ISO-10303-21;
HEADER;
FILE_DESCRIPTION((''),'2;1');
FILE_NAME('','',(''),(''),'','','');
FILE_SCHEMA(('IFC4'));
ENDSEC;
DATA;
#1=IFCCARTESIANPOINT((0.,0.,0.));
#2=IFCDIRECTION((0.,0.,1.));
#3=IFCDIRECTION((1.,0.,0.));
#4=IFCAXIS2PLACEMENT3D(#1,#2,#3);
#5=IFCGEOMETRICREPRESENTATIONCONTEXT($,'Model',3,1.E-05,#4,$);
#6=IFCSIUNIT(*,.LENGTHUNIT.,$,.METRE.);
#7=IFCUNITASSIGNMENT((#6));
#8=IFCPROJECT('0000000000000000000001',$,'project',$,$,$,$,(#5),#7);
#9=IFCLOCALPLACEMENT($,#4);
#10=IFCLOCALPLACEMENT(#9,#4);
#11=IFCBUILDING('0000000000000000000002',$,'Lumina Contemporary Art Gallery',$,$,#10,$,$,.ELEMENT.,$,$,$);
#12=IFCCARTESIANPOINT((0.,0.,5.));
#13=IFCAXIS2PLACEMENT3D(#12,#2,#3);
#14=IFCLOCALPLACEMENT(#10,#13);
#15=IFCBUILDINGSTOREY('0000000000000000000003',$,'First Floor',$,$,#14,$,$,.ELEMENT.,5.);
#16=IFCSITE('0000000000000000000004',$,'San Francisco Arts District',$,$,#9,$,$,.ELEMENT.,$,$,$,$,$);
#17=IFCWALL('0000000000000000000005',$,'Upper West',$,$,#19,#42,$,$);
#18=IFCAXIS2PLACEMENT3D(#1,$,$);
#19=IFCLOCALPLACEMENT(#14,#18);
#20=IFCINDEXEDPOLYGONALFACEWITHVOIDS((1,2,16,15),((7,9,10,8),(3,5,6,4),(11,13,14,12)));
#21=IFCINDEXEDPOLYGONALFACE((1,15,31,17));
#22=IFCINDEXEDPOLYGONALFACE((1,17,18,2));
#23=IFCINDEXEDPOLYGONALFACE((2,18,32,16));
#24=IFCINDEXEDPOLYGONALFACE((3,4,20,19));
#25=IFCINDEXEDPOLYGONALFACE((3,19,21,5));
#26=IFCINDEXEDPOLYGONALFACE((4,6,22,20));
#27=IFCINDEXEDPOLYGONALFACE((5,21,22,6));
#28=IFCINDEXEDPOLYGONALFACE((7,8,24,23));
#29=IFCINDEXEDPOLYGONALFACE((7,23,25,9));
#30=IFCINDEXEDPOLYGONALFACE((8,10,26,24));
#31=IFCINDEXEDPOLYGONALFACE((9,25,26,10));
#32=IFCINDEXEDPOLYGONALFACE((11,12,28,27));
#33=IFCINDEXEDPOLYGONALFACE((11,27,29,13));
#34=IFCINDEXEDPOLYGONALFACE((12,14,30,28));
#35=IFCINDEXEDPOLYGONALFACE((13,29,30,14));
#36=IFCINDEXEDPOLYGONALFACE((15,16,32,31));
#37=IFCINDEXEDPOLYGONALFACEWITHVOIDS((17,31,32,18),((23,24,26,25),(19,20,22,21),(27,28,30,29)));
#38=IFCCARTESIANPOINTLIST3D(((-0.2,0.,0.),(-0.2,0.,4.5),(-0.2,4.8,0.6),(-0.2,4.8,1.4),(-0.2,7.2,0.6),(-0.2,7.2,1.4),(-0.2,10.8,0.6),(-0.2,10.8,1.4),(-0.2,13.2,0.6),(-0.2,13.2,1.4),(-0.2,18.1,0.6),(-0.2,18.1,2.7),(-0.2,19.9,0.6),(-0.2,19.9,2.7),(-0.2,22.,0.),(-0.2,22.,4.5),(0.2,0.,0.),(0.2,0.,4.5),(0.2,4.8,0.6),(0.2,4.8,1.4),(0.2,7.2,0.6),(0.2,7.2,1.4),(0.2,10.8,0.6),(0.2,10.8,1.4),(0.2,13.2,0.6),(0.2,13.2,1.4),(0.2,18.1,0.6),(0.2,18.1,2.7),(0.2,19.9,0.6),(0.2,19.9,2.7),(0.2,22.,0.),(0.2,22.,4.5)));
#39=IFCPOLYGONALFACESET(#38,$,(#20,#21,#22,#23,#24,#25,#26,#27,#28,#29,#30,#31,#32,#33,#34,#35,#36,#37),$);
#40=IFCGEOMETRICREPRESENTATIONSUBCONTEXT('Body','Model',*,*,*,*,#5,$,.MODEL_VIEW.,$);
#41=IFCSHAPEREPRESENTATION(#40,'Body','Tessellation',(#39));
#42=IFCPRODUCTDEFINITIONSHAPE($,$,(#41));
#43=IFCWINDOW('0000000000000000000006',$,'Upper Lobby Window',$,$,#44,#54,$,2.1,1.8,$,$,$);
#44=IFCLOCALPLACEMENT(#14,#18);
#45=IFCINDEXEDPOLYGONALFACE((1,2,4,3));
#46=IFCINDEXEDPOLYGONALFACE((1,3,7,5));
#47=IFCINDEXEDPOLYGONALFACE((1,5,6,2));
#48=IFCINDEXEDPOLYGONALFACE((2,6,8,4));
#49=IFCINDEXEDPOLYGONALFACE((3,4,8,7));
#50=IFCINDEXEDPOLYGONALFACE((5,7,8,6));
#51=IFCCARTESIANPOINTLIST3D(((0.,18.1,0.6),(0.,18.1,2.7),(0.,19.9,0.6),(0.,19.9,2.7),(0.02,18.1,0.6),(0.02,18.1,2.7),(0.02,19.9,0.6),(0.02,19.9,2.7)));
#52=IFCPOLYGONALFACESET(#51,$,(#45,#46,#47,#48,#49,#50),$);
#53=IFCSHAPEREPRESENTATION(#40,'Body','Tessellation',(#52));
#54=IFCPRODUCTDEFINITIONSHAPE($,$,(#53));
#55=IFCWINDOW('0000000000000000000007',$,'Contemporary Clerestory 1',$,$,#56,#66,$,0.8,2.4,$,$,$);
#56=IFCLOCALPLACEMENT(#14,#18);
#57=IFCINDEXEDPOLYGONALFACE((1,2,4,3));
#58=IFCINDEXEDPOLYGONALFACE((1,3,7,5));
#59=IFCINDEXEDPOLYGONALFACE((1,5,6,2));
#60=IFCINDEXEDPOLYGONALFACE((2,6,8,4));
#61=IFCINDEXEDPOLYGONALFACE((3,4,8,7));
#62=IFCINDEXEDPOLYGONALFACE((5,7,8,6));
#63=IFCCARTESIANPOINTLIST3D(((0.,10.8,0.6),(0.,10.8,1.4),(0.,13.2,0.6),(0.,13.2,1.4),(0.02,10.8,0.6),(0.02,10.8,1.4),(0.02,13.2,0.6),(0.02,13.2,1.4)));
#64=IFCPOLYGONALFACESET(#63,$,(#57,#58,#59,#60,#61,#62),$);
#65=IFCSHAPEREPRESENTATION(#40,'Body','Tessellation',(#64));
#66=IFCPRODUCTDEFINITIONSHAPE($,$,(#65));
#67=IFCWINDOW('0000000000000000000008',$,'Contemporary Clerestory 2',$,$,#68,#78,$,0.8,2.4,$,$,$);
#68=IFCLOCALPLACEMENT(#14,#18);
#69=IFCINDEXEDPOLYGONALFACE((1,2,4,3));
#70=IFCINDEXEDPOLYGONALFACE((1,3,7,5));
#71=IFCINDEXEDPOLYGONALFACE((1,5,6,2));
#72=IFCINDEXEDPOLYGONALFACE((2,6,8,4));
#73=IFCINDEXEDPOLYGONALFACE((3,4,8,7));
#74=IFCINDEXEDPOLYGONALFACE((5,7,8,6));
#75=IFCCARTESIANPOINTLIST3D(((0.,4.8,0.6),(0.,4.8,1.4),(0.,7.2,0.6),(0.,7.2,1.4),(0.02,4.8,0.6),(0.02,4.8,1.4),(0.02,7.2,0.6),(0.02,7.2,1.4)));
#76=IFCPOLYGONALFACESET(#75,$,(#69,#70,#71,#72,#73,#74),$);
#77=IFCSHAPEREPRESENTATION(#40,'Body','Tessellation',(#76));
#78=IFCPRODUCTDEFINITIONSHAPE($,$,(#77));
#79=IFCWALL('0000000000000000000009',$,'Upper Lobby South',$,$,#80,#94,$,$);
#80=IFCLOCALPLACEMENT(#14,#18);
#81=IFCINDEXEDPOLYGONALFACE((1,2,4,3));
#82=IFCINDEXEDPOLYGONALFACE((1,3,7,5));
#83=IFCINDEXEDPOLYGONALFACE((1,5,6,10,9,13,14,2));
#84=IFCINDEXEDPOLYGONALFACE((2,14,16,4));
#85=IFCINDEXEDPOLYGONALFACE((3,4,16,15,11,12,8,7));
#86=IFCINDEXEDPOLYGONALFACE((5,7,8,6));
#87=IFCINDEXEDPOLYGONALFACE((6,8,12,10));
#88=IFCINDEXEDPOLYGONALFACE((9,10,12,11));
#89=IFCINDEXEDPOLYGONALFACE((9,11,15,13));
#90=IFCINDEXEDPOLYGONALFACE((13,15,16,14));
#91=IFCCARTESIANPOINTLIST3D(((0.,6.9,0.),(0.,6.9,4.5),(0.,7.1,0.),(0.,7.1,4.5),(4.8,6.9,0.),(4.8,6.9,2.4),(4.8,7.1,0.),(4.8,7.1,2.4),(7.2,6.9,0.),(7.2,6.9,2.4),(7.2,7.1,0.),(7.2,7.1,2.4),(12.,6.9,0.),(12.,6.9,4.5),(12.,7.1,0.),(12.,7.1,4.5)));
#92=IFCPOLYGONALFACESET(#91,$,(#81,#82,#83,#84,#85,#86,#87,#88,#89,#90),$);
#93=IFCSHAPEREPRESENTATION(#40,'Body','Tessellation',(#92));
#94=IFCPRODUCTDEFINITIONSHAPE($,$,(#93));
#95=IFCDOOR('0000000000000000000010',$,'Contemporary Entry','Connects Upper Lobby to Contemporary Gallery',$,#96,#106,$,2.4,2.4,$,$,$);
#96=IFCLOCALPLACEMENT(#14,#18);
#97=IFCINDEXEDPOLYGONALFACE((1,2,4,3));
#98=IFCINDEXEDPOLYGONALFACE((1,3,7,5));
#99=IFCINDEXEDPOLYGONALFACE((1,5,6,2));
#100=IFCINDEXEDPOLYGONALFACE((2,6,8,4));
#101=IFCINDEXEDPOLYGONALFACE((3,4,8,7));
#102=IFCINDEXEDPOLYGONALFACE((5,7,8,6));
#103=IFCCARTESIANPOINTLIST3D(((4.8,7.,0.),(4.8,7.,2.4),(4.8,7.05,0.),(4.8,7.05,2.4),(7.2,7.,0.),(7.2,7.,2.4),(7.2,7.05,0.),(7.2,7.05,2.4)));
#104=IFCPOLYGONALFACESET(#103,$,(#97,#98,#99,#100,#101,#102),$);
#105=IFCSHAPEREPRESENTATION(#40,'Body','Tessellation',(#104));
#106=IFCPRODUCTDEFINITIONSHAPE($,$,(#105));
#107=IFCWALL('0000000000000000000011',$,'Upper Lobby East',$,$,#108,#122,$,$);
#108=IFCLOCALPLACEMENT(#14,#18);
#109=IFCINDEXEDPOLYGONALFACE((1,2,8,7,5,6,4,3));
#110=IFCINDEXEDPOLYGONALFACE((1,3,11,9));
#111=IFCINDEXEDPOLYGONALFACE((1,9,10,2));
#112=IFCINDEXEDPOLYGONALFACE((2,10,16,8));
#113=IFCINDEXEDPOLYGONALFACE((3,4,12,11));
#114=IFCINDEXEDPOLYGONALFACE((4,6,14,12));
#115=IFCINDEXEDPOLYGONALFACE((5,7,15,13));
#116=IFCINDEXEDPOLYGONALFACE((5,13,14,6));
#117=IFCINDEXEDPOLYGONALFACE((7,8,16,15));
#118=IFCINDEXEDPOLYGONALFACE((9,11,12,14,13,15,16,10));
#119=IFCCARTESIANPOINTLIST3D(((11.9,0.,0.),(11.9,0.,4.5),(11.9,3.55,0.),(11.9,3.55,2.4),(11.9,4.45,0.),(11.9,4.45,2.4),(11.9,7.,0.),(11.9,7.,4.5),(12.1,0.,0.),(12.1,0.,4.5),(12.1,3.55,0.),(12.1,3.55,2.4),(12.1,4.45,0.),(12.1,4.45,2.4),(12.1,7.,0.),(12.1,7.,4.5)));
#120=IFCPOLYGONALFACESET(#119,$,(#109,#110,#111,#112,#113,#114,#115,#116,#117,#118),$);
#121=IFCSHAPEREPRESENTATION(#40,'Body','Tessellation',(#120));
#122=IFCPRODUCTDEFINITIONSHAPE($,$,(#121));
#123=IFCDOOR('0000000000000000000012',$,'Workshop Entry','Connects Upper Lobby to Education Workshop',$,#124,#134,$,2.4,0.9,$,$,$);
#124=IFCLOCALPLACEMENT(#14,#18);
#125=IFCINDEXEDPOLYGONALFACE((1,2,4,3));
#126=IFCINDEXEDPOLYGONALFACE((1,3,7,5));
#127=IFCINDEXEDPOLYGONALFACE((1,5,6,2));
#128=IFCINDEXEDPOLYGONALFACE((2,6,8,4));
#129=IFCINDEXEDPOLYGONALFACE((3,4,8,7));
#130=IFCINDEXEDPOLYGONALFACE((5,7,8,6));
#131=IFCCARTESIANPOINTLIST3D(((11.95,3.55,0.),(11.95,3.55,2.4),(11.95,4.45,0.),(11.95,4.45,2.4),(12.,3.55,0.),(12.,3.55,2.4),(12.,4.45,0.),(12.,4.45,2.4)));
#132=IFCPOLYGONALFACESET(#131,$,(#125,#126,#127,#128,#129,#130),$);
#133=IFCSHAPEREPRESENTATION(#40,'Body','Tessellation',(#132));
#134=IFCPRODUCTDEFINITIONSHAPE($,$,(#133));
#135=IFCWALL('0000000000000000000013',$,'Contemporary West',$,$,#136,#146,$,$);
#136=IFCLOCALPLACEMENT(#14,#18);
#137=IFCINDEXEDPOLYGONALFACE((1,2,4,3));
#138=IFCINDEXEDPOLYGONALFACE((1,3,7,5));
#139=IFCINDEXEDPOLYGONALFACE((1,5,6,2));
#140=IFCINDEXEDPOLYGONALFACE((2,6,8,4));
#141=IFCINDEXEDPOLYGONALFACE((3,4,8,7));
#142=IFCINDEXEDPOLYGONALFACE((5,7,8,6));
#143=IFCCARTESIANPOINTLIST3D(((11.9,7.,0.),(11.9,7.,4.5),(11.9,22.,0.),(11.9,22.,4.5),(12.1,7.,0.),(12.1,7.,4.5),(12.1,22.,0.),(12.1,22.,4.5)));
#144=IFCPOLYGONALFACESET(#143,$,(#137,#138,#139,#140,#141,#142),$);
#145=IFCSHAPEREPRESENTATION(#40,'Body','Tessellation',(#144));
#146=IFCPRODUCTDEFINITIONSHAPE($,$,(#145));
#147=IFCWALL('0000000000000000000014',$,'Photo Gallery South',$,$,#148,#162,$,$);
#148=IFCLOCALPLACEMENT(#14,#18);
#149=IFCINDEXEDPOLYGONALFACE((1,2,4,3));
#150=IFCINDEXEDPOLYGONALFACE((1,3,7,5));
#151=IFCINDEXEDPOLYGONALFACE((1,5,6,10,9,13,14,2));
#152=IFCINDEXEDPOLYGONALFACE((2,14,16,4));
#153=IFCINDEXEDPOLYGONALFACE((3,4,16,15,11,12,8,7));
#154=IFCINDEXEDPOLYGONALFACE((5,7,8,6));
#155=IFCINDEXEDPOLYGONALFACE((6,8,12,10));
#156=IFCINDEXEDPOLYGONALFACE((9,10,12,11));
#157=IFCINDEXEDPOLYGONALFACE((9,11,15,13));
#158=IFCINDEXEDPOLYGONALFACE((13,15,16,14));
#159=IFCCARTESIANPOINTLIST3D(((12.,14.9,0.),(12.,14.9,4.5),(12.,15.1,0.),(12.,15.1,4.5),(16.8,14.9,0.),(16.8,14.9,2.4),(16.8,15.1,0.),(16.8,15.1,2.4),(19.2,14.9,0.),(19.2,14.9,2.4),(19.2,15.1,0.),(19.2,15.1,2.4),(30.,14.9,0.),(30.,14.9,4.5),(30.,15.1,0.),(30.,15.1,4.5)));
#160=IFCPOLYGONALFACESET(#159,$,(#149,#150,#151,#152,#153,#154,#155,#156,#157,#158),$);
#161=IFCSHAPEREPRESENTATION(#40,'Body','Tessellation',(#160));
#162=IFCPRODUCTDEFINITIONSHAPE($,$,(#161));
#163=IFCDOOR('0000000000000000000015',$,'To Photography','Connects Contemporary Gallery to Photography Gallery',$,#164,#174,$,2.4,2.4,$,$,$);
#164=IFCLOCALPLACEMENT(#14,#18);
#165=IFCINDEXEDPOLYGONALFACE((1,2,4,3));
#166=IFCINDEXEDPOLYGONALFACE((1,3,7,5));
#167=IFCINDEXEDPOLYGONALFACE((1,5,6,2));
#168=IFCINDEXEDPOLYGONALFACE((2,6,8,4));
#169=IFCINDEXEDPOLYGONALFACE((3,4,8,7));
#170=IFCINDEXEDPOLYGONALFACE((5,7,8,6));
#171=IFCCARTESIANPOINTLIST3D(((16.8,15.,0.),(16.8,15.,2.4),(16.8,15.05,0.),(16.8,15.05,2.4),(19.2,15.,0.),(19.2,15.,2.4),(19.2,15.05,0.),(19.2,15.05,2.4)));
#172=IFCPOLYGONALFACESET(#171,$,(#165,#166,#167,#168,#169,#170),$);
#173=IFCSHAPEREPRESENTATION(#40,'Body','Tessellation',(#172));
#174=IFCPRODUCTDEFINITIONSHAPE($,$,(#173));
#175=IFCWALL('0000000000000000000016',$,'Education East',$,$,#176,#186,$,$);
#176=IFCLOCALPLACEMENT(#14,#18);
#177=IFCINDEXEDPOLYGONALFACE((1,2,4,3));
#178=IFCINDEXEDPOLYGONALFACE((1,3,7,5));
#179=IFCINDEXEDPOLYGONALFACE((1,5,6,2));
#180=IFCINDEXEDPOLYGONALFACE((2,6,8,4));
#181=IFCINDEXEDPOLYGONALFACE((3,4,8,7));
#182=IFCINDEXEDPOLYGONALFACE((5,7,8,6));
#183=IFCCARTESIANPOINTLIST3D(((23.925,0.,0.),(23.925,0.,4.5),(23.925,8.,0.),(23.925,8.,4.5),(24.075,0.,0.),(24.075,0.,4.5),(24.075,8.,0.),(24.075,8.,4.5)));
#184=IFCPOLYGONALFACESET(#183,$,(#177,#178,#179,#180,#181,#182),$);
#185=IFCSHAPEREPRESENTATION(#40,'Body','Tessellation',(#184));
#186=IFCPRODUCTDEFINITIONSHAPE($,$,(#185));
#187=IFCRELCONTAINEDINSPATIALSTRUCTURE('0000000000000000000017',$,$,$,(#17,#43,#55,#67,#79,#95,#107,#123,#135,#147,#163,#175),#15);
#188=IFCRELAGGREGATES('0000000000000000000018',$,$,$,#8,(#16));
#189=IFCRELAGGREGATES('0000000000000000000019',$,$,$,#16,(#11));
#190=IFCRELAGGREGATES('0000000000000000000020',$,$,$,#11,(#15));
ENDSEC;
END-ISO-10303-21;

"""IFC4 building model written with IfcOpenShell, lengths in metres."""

from ifc_helpers import new_model, si_unit, frame, origin_with_axes, place, context, subcontext, project, spatial, polyline, outline, extrude, element, fill, save


model = new_model("IFC4")

# Units and contexts
model_context = context("Model", 3, precision=1e-05, world=origin_with_axes())
body_context = subcontext(model_context, "Body", "Model", "MODEL_VIEW")
ifc_project = project(units=[si_unit("LENGTHUNIT", "METRE")], contexts=[model_context])

# Site, building, storey
site_placement = place(None, origin_with_axes())
site = spatial("IfcSite", under=ifc_project, at=site_placement, Name="San Francisco Arts District", CompositionType="ELEMENT")
building_placement = place(site_placement, origin_with_axes())
building = spatial("IfcBuilding", under=site, at=building_placement, Name="Lumina Contemporary Art Gallery", CompositionType="ELEMENT")
storey_placement = place(building_placement, frame((0.0, 0.0, 5.0), z_axis=(0.0, 0.0, 1.0), x_axis=(1.0, 0.0, 0.0)))
storey = spatial("IfcBuildingStorey", under=building, at=storey_placement, Name="First Floor", CompositionType="ELEMENT", Elevation=5.0)

# Wall, openings, windows
wall_1_placement = place(storey_placement, origin_with_axes())
wall_1 = element("IfcWall", 1, at=wall_1_placement, inside=storey, Name="Upper West", context=body_context, shape_type="SweptSolid", body=[
    extrude(outline(polyline([(-0.2, 22.0, 0.0), (-0.2, 0.0, 0.0), (0.2, 0.0, 0.0), (0.2, 22.0, 0.0), (-0.2, 22.0, 0.0)])), None, (0.0, 0.0, 1.0), 4.5),
])
opening_1_placement = place(storey_placement, origin_with_axes())
opening_1 = element("IfcOpeningElement", 2, at=opening_1_placement, inside=storey, cuts=wall_1, context=body_context, shape_type="SweptSolid", body=[
    extrude(outline(polyline([(-0.4, 19.9, 0.6), (-0.4, 18.1, 0.6), (0.4, 18.1, 0.6), (0.4, 19.9, 0.6), (-0.4, 19.9, 0.6)])), None, (0.0, 0.0, 1.0), 2.1),
])
opening_2_placement = place(storey_placement, origin_with_axes())
opening_2 = element("IfcOpeningElement", 3, at=opening_2_placement, inside=storey, cuts=wall_1, context=body_context, shape_type="SweptSolid", body=[
    extrude(outline(polyline([(-0.4, 13.2, 0.6), (-0.4, 10.8, 0.6), (0.4, 10.8, 0.6), (0.4, 13.2, 0.6), (-0.4, 13.2, 0.6)])), None, (0.0, 0.0, 1.0), 0.8),
])
opening_3_placement = place(storey_placement, origin_with_axes())
opening_3 = element("IfcOpeningElement", 4, at=opening_3_placement, inside=storey, cuts=wall_1, context=body_context, shape_type="SweptSolid", body=[
    extrude(outline(polyline([(-0.4, 7.2, 0.6), (-0.4, 4.8, 0.6), (0.4, 4.8, 0.6), (0.4, 7.2, 0.6), (-0.4, 7.2, 0.6)])), None, (0.0, 0.0, 1.0), 0.8),
])
window_1_placement = place(storey_placement, origin_with_axes())
window_1 = element("IfcWindow", 5, at=window_1_placement, inside=storey, Name="Upper Lobby Window", OverallHeight=2.1, OverallWidth=1.8, context=body_context, shape_type="SweptSolid", body=[
    extrude(outline(polyline([(0.0, 19.9, 0.6), (0.0, 18.1, 0.6), (0.02, 18.1, 0.6), (0.02, 19.9, 0.6), (0.0, 19.9, 0.6)])), None, (0.0, 0.0, 1.0), 2.1),
])
fill(opening_1, window_1)
window_2_placement = place(storey_placement, origin_with_axes())
window_2 = element("IfcWindow", 6, at=window_2_placement, inside=storey, Name="Contemporary Clerestory 1", OverallHeight=0.8, OverallWidth=2.4, context=body_context, shape_type="SweptSolid", body=[
    extrude(outline(polyline([(0.0, 13.2, 0.6), (0.0, 10.8, 0.6), (0.02, 10.8, 0.6), (0.02, 13.2, 0.6), (0.0, 13.2, 0.6)])), None, (0.0, 0.0, 1.0), 0.8),
])
fill(opening_2, window_2)
window_3_placement = place(storey_placement, origin_with_axes())
window_3 = element("IfcWindow", 7, at=window_3_placement, inside=storey, Name="Contemporary Clerestory 2", OverallHeight=0.8, OverallWidth=2.4, context=body_context, shape_type="SweptSolid", body=[
    extrude(outline(polyline([(0.0, 7.2, 0.6), (0.0, 4.8, 0.6), (0.02, 4.8, 0.6), (0.02, 7.2, 0.6), (0.0, 7.2, 0.6)])), None, (0.0, 0.0, 1.0), 0.8),
])
fill(opening_3, window_3)

# Walls, openings, doors
wall_2_placement = place(storey_placement, origin_with_axes())
wall_2 = element("IfcWall", 8, at=wall_2_placement, inside=storey, Name="Upper Lobby South", context=body_context, shape_type="SweptSolid", body=[
    extrude(outline(polyline([(0.0, 6.9, 0.0), (12.0, 6.9, 0.0), (12.0, 7.1, 0.0), (0.0, 7.1, 0.0), (0.0, 6.9, 0.0)])), None, (0.0, 0.0, 1.0), 4.5),
])
opening_4_placement = place(storey_placement, origin_with_axes())
opening_4 = element("IfcOpeningElement", 9, at=opening_4_placement, inside=storey, cuts=wall_2, context=body_context, shape_type="SweptSolid", body=[
    extrude(outline(polyline([(4.8, 6.8, 0.0), (7.2, 6.8, 0.0), (7.2, 7.2, 0.0), (4.8, 7.2, 0.0), (4.8, 6.8, 0.0)])), None, (0.0, 0.0, 1.0), 2.4),
])
door_1_placement = place(storey_placement, origin_with_axes())
door_1 = element("IfcDoor", 10, at=door_1_placement, inside=storey, Name="Contemporary Entry", Description="Connects Upper Lobby to Contemporary Gallery", OverallHeight=2.4, OverallWidth=2.4, context=body_context, shape_type="SweptSolid", body=[
    extrude(outline(polyline([(4.8, 7.0, 0.0), (7.2, 7.0, 0.0), (7.2, 7.05, 0.0), (4.8, 7.05, 0.0), (4.8, 7.0, 0.0)])), None, (0.0, 0.0, 1.0), 2.4),
])
fill(opening_4, door_1)
wall_3_placement = place(storey_placement, origin_with_axes())
wall_3 = element("IfcWall", 11, at=wall_3_placement, inside=storey, Name="Upper Lobby East", context=body_context, shape_type="SweptSolid", body=[
    extrude(outline(polyline([(12.1, 0.0, 0.0), (12.1, 7.0, 0.0), (11.9, 7.0, 0.0), (11.9, 0.0, 0.0), (12.1, 0.0, 0.0)])), None, (0.0, 0.0, 1.0), 4.5),
])
opening_5_placement = place(storey_placement, origin_with_axes())
opening_5 = element("IfcOpeningElement", 12, at=opening_5_placement, inside=storey, cuts=wall_3, context=body_context, shape_type="SweptSolid", body=[
    extrude(outline(polyline([(12.2, 3.55, 0.0), (12.2, 4.45, 0.0), (11.8, 4.45, 0.0), (11.8, 3.55, 0.0), (12.2, 3.55, 0.0)])), None, (0.0, 0.0, 1.0), 2.4),
])
door_2_placement = place(storey_placement, origin_with_axes())
door_2 = element("IfcDoor", 13, at=door_2_placement, inside=storey, Name="Workshop Entry", Description="Connects Upper Lobby to Education Workshop", OverallHeight=2.4, OverallWidth=0.9, context=body_context, shape_type="SweptSolid", body=[
    extrude(outline(polyline([(12.0, 3.55, 0.0), (12.0, 4.45, 0.0), (11.95, 4.45, 0.0), (11.95, 3.55, 0.0), (12.0, 3.55, 0.0)])), None, (0.0, 0.0, 1.0), 2.4),
])
fill(opening_5, door_2)

# Wall
wall_4_placement = place(storey_placement, origin_with_axes())
element("IfcWall", 14, at=wall_4_placement, inside=storey, Name="Contemporary West", context=body_context, shape_type="SweptSolid", body=[
    extrude(outline(polyline([(12.1, 7.0, 0.0), (12.1, 22.0, 0.0), (11.9, 22.0, 0.0), (11.9, 7.0, 0.0), (12.1, 7.0, 0.0)])), None, (0.0, 0.0, 1.0), 4.5),
])

# Wall, opening, door
wall_5_placement = place(storey_placement, origin_with_axes())
wall_5 = element("IfcWall", 15, at=wall_5_placement, inside=storey, Name="Photo Gallery South", context=body_context, shape_type="SweptSolid", body=[
    extrude(outline(polyline([(12.0, 14.9, 0.0), (30.0, 14.9, 0.0), (30.0, 15.1, 0.0), (12.0, 15.1, 0.0), (12.0, 14.9, 0.0)])), None, (0.0, 0.0, 1.0), 4.5),
])
opening_6_placement = place(storey_placement, origin_with_axes())
opening_6 = element("IfcOpeningElement", 16, at=opening_6_placement, inside=storey, cuts=wall_5, context=body_context, shape_type="SweptSolid", body=[
    extrude(outline(polyline([(16.8, 14.8, 0.0), (19.2, 14.8, 0.0), (19.2, 15.2, 0.0), (16.8, 15.2, 0.0), (16.8, 14.8, 0.0)])), None, (0.0, 0.0, 1.0), 2.4),
])
door_3_placement = place(storey_placement, origin_with_axes())
door_3 = element("IfcDoor", 17, at=door_3_placement, inside=storey, Name="To Photography", Description="Connects Contemporary Gallery to Photography Gallery", OverallHeight=2.4, OverallWidth=2.4, context=body_context, shape_type="SweptSolid", body=[
    extrude(outline(polyline([(16.8, 15.0, 0.0), (19.2, 15.0, 0.0), (19.2, 15.05, 0.0), (16.8, 15.05, 0.0), (16.8, 15.0, 0.0)])), None, (0.0, 0.0, 1.0), 2.4),
])
fill(opening_6, door_3)

# Wall
wall_6_placement = place(storey_placement, origin_with_axes())
element("IfcWall", 18, at=wall_6_placement, inside=storey, Name="Education East", context=body_context, shape_type="SweptSolid", body=[
    extrude(outline(polyline([(24.075, 0.0, 0.0), (24.075, 8.0, 0.0), (23.925, 8.0, 0.0), (23.925, 0.0, 0.0), (24.075, 0.0, 0.0)])), None, (0.0, 0.0, 1.0), 4.5),
])

save(model, "model.ifc")
